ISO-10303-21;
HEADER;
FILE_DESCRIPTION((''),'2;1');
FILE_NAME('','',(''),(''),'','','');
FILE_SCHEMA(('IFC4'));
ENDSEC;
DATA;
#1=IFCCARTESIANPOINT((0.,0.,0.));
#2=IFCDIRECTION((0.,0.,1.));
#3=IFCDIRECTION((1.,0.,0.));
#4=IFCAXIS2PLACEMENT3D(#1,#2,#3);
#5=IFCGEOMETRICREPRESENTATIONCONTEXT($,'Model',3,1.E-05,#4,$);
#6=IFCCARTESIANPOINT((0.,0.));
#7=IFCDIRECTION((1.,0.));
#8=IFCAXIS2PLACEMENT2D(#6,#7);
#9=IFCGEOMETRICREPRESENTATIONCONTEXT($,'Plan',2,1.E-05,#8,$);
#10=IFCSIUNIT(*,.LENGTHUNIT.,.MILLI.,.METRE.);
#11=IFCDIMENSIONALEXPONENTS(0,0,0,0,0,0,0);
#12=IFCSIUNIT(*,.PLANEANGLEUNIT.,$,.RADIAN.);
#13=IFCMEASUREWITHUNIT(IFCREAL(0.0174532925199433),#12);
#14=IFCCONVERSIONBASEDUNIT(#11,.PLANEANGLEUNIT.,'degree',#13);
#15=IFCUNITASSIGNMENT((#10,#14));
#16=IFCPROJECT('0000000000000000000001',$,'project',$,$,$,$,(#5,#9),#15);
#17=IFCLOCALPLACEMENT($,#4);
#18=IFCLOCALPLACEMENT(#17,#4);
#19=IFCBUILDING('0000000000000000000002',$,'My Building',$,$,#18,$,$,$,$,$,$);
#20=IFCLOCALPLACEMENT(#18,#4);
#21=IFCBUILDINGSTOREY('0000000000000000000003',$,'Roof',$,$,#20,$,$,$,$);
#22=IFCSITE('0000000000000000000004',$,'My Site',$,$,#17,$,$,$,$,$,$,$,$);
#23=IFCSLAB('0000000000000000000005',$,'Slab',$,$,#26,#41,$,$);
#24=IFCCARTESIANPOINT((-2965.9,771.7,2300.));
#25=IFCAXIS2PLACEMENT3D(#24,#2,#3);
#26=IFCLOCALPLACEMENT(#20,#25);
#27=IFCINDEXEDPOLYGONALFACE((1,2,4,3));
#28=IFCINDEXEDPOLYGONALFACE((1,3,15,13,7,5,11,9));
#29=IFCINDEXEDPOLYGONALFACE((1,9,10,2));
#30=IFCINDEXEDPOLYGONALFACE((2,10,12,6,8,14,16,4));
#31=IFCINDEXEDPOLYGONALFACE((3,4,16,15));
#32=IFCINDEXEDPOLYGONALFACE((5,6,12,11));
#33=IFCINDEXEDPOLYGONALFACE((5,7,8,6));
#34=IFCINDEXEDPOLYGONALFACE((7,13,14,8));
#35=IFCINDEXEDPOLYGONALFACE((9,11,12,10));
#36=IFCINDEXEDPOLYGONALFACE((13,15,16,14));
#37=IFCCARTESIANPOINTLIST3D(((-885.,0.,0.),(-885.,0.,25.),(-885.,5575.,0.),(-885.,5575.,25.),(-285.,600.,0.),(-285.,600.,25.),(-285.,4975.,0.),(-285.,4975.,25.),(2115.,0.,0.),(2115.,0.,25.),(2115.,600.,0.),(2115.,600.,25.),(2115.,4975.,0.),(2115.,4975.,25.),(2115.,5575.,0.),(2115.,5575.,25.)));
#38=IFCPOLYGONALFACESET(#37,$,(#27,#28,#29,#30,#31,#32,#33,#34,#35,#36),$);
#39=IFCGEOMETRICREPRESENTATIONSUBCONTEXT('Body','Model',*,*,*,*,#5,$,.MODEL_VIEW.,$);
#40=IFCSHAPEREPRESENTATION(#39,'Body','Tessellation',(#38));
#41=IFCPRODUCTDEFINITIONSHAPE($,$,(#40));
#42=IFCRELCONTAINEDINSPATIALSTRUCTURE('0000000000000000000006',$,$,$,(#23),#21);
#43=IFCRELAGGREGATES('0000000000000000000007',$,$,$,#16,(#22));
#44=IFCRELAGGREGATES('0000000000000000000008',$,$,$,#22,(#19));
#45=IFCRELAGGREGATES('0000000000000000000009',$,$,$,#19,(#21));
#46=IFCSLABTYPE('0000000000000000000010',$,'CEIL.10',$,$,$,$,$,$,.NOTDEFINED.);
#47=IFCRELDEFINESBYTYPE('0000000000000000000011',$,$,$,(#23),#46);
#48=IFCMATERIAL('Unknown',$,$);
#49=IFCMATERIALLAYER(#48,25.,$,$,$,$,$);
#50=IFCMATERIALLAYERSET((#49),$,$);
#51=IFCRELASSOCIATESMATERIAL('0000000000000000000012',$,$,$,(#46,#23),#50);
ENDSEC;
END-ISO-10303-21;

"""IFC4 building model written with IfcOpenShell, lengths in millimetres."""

from ifc_helpers import new_model, entity, si_unit, converted_unit, frame, origin_with_axes, origin_2d_with_axis, place, context, subcontext, project, spatial, line, indexed_curve, outline, extrude, material, layer, layer_set, layer_usage, type_object, element, save


model = new_model("IFC4")

# Units and contexts
model_context = context("Model", 3, precision=1e-05, world=origin_with_axes())
plan_context = context("Plan", 2, precision=1e-05, world=origin_2d_with_axis())
body_context = subcontext(model_context, "Body", "Model", "MODEL_VIEW")
ifc_project = project(units=[si_unit("LENGTHUNIT", "METRE", prefix="MILLI"), converted_unit("PLANEANGLEUNIT", "degree", entity("IfcReal", 0.0174532925199433), si_unit("PLANEANGLEUNIT", "RADIAN"), dimensions=[0, 0, 0, 0, 0, 0, 0])], contexts=[model_context, plan_context])

# Site, building, storey
site_placement = place(None, origin_with_axes())
site = spatial("IfcSite", under=ifc_project, at=site_placement, Name="My Site")
building_placement = place(site_placement, origin_with_axes())
building = spatial("IfcBuilding", under=site, at=building_placement, Name="My Building")
storey_placement = place(building_placement, origin_with_axes())
storey = spatial("IfcBuildingStorey", under=building, at=storey_placement, Name="Roof")

# Slab
ifc_material = material(Name="Unknown")
ifc_layer_1 = layer(ifc_material, 25.0)
ifc_layer_set_1 = layer_set([ifc_layer_1])
slab_type_1 = type_object("IfcSlabType", Name="CEIL.10", PredefinedType="NOTDEFINED", material=ifc_layer_set_1)
ifc_layer_usage_1 = layer_usage(ifc_layer_set_1, "AXIS3", "POSITIVE", 0.0)
slab_1_placement = place(storey_placement, frame((-2965.9, 771.7, 2300.0), z_axis=(0.0, 0.0, 1.0), x_axis=(1.0, 0.0, 0.0)))
element("IfcSlab", 1, at=slab_1_placement, inside=storey, type_object=slab_type_1, material=ifc_layer_usage_1, Name="Slab", context=body_context, shape_type="SweptSolid", body=[
    extrude(outline(indexed_curve([(2115.0, 600.0), (2115.0, 0.0), (-885.0, 0.0), (-885.0, 5575.0), (-285.0, 600.0), (-285.0, 4975.0), (2115.0, 4975.0), (2115.0, 5575.0)], segments=[line(5, 1), line(1, 2), line(2, 3), line(3, 4), line(4, 8), line(8, 7), line(7, 6), line(6, 5)], self_intersect=False)), None, (0.0, 0.0, 1.0), 25.0),
])

save(model, "model.ifc")
